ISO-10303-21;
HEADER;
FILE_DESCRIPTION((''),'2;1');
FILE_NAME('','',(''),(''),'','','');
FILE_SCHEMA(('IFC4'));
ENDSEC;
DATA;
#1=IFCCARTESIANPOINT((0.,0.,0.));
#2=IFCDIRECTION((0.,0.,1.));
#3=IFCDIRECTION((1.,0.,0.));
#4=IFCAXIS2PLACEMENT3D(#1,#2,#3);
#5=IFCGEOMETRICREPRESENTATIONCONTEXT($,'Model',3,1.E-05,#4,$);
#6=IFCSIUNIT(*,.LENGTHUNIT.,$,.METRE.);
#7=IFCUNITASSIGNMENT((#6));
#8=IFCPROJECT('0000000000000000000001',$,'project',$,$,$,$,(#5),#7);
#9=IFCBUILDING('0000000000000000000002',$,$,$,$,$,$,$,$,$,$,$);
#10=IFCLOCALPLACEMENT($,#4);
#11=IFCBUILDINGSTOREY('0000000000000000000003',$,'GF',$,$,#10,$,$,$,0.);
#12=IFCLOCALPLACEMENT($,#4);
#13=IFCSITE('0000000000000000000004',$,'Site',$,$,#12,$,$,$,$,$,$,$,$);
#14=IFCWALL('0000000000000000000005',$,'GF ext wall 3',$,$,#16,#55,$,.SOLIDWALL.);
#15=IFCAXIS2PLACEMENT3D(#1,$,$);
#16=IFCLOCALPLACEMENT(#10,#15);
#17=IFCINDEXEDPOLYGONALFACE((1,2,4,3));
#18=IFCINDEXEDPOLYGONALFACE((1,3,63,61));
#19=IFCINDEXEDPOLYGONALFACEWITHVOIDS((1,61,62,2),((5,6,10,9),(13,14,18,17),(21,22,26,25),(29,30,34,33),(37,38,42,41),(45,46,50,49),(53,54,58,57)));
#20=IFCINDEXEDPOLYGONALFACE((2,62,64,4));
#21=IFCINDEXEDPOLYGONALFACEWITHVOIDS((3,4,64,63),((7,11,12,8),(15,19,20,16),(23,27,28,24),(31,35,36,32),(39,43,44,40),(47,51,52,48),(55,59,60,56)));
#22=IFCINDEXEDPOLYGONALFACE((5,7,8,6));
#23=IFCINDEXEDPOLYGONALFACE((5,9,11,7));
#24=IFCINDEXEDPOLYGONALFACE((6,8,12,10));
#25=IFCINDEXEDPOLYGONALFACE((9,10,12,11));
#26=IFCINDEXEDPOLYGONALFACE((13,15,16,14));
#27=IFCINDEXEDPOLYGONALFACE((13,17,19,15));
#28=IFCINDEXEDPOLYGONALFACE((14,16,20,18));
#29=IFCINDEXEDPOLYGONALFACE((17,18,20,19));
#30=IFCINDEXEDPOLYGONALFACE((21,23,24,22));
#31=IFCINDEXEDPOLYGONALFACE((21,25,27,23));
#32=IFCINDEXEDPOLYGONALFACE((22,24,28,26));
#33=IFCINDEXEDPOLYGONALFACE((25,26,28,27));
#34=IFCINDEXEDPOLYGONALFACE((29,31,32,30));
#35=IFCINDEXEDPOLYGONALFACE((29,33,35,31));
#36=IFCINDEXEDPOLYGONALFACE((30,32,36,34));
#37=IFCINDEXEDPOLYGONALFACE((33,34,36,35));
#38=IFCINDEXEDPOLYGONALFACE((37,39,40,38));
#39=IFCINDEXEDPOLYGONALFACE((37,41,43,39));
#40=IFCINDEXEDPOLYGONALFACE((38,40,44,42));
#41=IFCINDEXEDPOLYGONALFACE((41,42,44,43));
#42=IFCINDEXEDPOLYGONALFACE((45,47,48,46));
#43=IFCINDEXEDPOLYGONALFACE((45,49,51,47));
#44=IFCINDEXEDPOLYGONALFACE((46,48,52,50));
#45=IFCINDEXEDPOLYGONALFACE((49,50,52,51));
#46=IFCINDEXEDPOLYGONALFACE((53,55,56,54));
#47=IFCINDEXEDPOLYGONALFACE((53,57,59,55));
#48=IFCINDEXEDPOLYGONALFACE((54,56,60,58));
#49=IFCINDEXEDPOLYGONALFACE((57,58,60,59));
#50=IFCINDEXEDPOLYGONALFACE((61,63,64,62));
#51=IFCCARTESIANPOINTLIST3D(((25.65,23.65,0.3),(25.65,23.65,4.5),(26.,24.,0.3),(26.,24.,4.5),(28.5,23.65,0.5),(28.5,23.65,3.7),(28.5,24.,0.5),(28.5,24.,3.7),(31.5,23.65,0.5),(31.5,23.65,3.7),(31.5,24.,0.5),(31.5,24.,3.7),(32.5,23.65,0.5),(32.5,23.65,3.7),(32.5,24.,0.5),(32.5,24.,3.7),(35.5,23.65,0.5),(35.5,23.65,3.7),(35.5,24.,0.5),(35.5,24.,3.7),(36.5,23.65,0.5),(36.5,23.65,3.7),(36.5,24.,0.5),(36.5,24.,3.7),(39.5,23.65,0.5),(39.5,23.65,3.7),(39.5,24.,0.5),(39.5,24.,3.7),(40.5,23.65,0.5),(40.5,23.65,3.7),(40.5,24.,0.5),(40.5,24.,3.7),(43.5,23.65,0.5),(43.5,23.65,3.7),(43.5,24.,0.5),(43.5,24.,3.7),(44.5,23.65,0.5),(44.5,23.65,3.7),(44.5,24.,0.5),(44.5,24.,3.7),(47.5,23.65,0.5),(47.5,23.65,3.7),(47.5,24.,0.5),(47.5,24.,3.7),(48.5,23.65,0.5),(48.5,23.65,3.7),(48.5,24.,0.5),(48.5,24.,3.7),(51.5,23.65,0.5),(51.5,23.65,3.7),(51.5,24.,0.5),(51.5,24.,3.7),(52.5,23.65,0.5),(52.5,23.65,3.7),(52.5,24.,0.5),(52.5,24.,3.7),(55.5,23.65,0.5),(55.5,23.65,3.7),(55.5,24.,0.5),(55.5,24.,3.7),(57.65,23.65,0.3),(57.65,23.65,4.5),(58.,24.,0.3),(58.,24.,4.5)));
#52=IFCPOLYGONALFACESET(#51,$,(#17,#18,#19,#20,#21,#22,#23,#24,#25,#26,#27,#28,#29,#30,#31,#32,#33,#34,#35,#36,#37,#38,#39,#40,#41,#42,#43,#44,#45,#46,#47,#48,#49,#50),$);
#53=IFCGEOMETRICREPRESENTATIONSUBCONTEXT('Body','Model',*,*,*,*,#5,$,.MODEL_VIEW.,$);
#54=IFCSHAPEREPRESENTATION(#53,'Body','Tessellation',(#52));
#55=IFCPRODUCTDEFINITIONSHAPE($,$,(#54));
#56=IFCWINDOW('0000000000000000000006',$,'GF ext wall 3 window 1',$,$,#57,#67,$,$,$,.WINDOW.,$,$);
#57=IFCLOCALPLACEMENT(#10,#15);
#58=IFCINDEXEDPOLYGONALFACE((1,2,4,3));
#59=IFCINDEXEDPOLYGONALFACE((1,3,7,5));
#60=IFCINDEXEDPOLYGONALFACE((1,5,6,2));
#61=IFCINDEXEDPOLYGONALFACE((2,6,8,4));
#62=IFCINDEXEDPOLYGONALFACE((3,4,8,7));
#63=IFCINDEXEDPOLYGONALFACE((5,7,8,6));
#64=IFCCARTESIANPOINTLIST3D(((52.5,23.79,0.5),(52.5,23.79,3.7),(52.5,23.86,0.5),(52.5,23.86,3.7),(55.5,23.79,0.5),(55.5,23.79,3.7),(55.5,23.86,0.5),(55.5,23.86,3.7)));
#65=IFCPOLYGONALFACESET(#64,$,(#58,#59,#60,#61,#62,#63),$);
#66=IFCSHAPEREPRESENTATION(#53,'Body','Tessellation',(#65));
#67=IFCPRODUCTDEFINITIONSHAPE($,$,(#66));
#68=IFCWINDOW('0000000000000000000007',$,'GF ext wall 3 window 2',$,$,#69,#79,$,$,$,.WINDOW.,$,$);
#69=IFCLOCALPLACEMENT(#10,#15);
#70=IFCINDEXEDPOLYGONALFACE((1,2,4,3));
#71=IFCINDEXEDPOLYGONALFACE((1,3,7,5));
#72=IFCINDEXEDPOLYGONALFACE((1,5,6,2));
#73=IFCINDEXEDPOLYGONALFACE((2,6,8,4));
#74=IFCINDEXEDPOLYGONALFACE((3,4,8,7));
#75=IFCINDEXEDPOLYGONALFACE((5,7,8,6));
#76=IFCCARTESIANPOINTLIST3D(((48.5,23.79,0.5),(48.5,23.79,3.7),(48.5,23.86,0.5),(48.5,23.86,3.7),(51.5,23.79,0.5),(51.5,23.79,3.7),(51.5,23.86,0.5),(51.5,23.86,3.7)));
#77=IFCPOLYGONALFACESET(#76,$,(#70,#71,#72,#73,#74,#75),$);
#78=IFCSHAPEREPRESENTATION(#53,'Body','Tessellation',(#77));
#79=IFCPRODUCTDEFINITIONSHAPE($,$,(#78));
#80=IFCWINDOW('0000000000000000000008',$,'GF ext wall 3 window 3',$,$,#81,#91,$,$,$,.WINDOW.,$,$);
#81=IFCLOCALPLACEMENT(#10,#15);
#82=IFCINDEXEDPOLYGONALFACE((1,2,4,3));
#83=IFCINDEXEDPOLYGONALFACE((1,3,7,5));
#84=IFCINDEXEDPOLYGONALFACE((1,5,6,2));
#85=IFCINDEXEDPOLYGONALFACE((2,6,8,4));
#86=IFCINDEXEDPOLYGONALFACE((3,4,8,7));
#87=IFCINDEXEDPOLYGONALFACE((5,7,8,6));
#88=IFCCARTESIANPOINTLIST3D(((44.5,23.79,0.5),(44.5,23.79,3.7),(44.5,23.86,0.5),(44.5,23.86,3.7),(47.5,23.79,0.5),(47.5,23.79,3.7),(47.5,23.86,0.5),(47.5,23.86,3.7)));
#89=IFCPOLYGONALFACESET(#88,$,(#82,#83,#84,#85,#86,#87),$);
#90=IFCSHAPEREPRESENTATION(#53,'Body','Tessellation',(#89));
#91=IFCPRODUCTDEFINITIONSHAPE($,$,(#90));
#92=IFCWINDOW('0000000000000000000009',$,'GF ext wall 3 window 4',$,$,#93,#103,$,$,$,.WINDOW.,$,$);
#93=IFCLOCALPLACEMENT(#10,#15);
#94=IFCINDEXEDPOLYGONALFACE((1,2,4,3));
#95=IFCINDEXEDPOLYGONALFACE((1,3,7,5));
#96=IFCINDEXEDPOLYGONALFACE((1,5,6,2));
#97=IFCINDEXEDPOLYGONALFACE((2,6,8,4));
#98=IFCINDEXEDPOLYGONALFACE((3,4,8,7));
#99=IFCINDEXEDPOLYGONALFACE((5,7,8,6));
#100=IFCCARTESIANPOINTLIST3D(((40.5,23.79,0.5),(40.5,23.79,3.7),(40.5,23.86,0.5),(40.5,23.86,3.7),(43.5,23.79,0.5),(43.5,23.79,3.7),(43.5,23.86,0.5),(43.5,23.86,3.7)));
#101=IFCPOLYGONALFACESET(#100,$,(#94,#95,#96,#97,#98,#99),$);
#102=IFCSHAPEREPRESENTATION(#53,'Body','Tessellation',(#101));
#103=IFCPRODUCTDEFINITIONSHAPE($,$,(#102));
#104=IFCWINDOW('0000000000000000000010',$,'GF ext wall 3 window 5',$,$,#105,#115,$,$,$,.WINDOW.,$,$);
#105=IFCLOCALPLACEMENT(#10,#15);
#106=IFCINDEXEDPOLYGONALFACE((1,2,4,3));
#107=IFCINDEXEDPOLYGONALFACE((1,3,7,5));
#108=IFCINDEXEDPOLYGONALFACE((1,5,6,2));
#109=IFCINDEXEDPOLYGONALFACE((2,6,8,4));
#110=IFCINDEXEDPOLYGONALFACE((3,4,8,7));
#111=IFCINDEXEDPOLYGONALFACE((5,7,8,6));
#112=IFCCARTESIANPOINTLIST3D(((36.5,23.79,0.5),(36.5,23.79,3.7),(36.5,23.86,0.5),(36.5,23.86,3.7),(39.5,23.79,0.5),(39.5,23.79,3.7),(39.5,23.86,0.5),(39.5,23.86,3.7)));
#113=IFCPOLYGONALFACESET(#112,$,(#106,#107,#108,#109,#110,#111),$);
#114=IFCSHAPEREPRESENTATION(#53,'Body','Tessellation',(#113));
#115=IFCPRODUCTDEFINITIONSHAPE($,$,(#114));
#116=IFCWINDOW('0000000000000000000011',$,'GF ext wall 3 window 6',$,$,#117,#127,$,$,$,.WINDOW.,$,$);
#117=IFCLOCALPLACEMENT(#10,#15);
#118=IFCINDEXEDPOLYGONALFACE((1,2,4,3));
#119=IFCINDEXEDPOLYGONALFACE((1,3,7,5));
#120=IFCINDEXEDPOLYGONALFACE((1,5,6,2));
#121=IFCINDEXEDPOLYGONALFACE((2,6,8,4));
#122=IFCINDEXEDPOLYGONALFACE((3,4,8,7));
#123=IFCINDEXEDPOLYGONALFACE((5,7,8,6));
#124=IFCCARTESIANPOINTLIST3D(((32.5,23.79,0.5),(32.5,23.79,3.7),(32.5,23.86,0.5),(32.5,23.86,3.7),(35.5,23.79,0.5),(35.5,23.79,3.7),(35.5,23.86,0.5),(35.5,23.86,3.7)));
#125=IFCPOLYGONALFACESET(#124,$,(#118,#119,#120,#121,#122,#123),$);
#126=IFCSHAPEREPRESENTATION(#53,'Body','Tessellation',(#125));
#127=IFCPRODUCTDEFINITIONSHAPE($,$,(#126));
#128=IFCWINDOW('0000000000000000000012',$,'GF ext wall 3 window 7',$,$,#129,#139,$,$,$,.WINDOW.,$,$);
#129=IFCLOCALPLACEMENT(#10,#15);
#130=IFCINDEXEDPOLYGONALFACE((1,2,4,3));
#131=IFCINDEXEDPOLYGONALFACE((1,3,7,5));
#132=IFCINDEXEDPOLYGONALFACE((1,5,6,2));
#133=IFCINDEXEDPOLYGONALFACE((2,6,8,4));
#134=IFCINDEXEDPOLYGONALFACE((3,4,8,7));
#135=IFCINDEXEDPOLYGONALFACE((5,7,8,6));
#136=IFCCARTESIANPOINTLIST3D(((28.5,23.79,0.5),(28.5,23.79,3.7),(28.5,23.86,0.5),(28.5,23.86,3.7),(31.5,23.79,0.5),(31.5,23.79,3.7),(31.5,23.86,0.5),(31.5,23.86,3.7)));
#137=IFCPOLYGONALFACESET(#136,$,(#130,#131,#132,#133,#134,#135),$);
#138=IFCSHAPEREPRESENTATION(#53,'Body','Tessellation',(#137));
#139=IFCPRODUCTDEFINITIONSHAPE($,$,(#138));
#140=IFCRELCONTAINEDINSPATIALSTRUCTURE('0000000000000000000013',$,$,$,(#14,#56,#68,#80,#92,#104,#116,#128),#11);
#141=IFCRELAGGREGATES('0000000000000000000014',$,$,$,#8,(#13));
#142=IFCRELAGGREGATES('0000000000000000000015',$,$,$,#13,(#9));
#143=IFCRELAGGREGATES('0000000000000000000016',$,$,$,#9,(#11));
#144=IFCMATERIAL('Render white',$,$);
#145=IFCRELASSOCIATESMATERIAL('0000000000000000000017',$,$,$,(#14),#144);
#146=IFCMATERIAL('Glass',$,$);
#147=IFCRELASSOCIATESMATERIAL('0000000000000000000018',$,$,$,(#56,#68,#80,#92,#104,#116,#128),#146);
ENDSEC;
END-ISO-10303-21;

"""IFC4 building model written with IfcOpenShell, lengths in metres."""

from ifc_helpers import new_model, si_unit, frame, origin_with_axes, place, context, subcontext, project, spatial, polyline, outline, extrude, material, element, fill, save


model = new_model("IFC4")

# Units and contexts
model_context = context("Model", 3, precision=1e-05, world=origin_with_axes())
body_context = subcontext(model_context, "Body", "Model", "MODEL_VIEW")
ifc_project = project(units=[si_unit("LENGTHUNIT", "METRE")], contexts=[model_context])

# Site, building, storey
site_placement = place(None, origin_with_axes())
site = spatial("IfcSite", under=ifc_project, at=site_placement, Name="Site")
building = spatial("IfcBuilding", under=site)
storey_placement = place(None, origin_with_axes())
storey = spatial("IfcBuildingStorey", under=building, at=storey_placement, Name="GF", Elevation=0.0)

# Wall, openings, windows
ifc_material_1 = material(Name="Render white")
wall_1_placement = place(storey_placement, origin_with_axes())
wall_1 = element("IfcWall", 1, at=wall_1_placement, inside=storey, material=ifc_material_1, Name="GF ext wall 3", PredefinedType="SOLIDWALL", context=body_context, shape_type="SweptSolid", body=[
    extrude(outline(polyline([(58.0, 24.0), (26.0, 24.0), (25.65, 23.65), (57.65, 23.65), (58.0, 24.0)])), frame((0.0, 0.0, 0.3), z_axis=(0.0, 0.0, 1.0), x_axis=(1.0, 0.0, 0.0)), (0.0, 0.0, 1.0), 4.2),
])
opening_1_placement = place(wall_1_placement, origin_with_axes())
opening_1 = element("IfcOpeningElement", 2, at=opening_1_placement, cuts=wall_1, context=body_context, shape_type="SweptSolid", body=[
    extrude(outline(polyline([(55.5, 24.05), (52.5, 24.05), (52.5, 23.6), (55.5, 23.6), (55.5, 24.05)])), frame((0.0, 0.0, 0.5), z_axis=(0.0, 0.0, 1.0), x_axis=(1.0, 0.0, 0.0)), (0.0, 0.0, 1.0), 3.2),
])
opening_2_placement = place(wall_1_placement, origin_with_axes())
opening_2 = element("IfcOpeningElement", 3, at=opening_2_placement, cuts=wall_1, context=body_context, shape_type="SweptSolid", body=[
    extrude(outline(polyline([(51.5, 24.05), (48.5, 24.05), (48.5, 23.6), (51.5, 23.6), (51.5, 24.05)])), frame((0.0, 0.0, 0.5), z_axis=(0.0, 0.0, 1.0), x_axis=(1.0, 0.0, 0.0)), (0.0, 0.0, 1.0), 3.2),
])
opening_3_placement = place(wall_1_placement, origin_with_axes())
opening_3 = element("IfcOpeningElement", 4, at=opening_3_placement, cuts=wall_1, context=body_context, shape_type="SweptSolid", body=[
    extrude(outline(polyline([(47.5, 24.05), (44.5, 24.05), (44.5, 23.6), (47.5, 23.6), (47.5, 24.05)])), frame((0.0, 0.0, 0.5), z_axis=(0.0, 0.0, 1.0), x_axis=(1.0, 0.0, 0.0)), (0.0, 0.0, 1.0), 3.2),
])
opening_4_placement = place(wall_1_placement, origin_with_axes())
opening_4 = element("IfcOpeningElement", 5, at=opening_4_placement, cuts=wall_1, context=body_context, shape_type="SweptSolid", body=[
    extrude(outline(polyline([(43.5, 24.05), (40.5, 24.05), (40.5, 23.6), (43.5, 23.6), (43.5, 24.05)])), frame((0.0, 0.0, 0.5), z_axis=(0.0, 0.0, 1.0), x_axis=(1.0, 0.0, 0.0)), (0.0, 0.0, 1.0), 3.2),
])
opening_5_placement = place(wall_1_placement, origin_with_axes())
opening_5 = element("IfcOpeningElement", 6, at=opening_5_placement, cuts=wall_1, context=body_context, shape_type="SweptSolid", body=[
    extrude(outline(polyline([(39.5, 24.05), (36.5, 24.05), (36.5, 23.6), (39.5, 23.6), (39.5, 24.05)])), frame((0.0, 0.0, 0.5), z_axis=(0.0, 0.0, 1.0), x_axis=(1.0, 0.0, 0.0)), (0.0, 0.0, 1.0), 3.2),
])
opening_6_placement = place(wall_1_placement, origin_with_axes())
opening_6 = element("IfcOpeningElement", 7, at=opening_6_placement, cuts=wall_1, context=body_context, shape_type="SweptSolid", body=[
    extrude(outline(polyline([(35.5, 24.05), (32.5, 24.05), (32.5, 23.6), (35.5, 23.6), (35.5, 24.05)])), frame((0.0, 0.0, 0.5), z_axis=(0.0, 0.0, 1.0), x_axis=(1.0, 0.0, 0.0)), (0.0, 0.0, 1.0), 3.2),
])
opening_7_placement = place(wall_1_placement, origin_with_axes())
opening_7 = element("IfcOpeningElement", 8, at=opening_7_placement, cuts=wall_1, context=body_context, shape_type="SweptSolid", body=[
    extrude(outline(polyline([(31.5, 24.05), (28.5, 24.05), (28.5, 23.6), (31.5, 23.6), (31.5, 24.05)])), frame((0.0, 0.0, 0.5), z_axis=(0.0, 0.0, 1.0), x_axis=(1.0, 0.0, 0.0)), (0.0, 0.0, 1.0), 3.2),
])
ifc_material_2 = material(Name="Glass")
window_1_placement = place(storey_placement, origin_with_axes())
window_1 = element("IfcWindow", 9, at=window_1_placement, inside=storey, material=ifc_material_2, Name="GF ext wall 3 window 1", PredefinedType="WINDOW", context=body_context, shape_type="SweptSolid", body=[
    extrude(outline(polyline([(55.5, 23.86), (52.5, 23.86), (52.5, 23.79), (55.5, 23.79), (55.5, 23.86)])), frame((0.0, 0.0, 0.5), z_axis=(0.0, 0.0, 1.0), x_axis=(1.0, 0.0, 0.0)), (0.0, 0.0, 1.0), 3.2),
])
fill(opening_1, window_1)
window_2_placement = place(storey_placement, origin_with_axes())
window_2 = element("IfcWindow", 10, at=window_2_placement, inside=storey, material=ifc_material_2, Name="GF ext wall 3 window 2", PredefinedType="WINDOW", context=body_context, shape_type="SweptSolid", body=[
    extrude(outline(polyline([(51.5, 23.86), (48.5, 23.86), (48.5, 23.79), (51.5, 23.79), (51.5, 23.86)])), frame((0.0, 0.0, 0.5), z_axis=(0.0, 0.0, 1.0), x_axis=(1.0, 0.0, 0.0)), (0.0, 0.0, 1.0), 3.2),
])
fill(opening_2, window_2)
window_3_placement = place(storey_placement, origin_with_axes())
window_3 = element("IfcWindow", 11, at=window_3_placement, inside=storey, material=ifc_material_2, Name="GF ext wall 3 window 3", PredefinedType="WINDOW", context=body_context, shape_type="SweptSolid", body=[
    extrude(outline(polyline([(47.5, 23.86), (44.5, 23.86), (44.5, 23.79), (47.5, 23.79), (47.5, 23.86)])), frame((0.0, 0.0, 0.5), z_axis=(0.0, 0.0, 1.0), x_axis=(1.0, 0.0, 0.0)), (0.0, 0.0, 1.0), 3.2),
])
fill(opening_3, window_3)
window_4_placement = place(storey_placement, origin_with_axes())
window_4 = element("IfcWindow", 12, at=window_4_placement, inside=storey, material=ifc_material_2, Name="GF ext wall 3 window 4", PredefinedType="WINDOW", context=body_context, shape_type="SweptSolid", body=[
    extrude(outline(polyline([(43.5, 23.86), (40.5, 23.86), (40.5, 23.79), (43.5, 23.79), (43.5, 23.86)])), frame((0.0, 0.0, 0.5), z_axis=(0.0, 0.0, 1.0), x_axis=(1.0, 0.0, 0.0)), (0.0, 0.0, 1.0), 3.2),
])
fill(opening_4, window_4)
window_5_placement = place(storey_placement, origin_with_axes())
window_5 = element("IfcWindow", 13, at=window_5_placement, inside=storey, material=ifc_material_2, Name="GF ext wall 3 window 5", PredefinedType="WINDOW", context=body_context, shape_type="SweptSolid", body=[
    extrude(outline(polyline([(39.5, 23.86), (36.5, 23.86), (36.5, 23.79), (39.5, 23.79), (39.5, 23.86)])), frame((0.0, 0.0, 0.5), z_axis=(0.0, 0.0, 1.0), x_axis=(1.0, 0.0, 0.0)), (0.0, 0.0, 1.0), 3.2),
])
fill(opening_5, window_5)
window_6_placement = place(storey_placement, origin_with_axes())
window_6 = element("IfcWindow", 14, at=window_6_placement, inside=storey, material=ifc_material_2, Name="GF ext wall 3 window 6", PredefinedType="WINDOW", context=body_context, shape_type="SweptSolid", body=[
    extrude(outline(polyline([(35.5, 23.86), (32.5, 23.86), (32.5, 23.79), (35.5, 23.79), (35.5, 23.86)])), frame((0.0, 0.0, 0.5), z_axis=(0.0, 0.0, 1.0), x_axis=(1.0, 0.0, 0.0)), (0.0, 0.0, 1.0), 3.2),
])
fill(opening_6, window_6)
window_7_placement = place(storey_placement, origin_with_axes())
window_7 = element("IfcWindow", 15, at=window_7_placement, inside=storey, material=ifc_material_2, Name="GF ext wall 3 window 7", PredefinedType="WINDOW", context=body_context, shape_type="SweptSolid", body=[
    extrude(outline(polyline([(31.5, 23.86), (28.5, 23.86), (28.5, 23.79), (31.5, 23.79), (31.5, 23.86)])), frame((0.0, 0.0, 0.5), z_axis=(0.0, 0.0, 1.0), x_axis=(1.0, 0.0, 0.0)), (0.0, 0.0, 1.0), 3.2),
])
fill(opening_7, window_7)

save(model, "model.ifc")
